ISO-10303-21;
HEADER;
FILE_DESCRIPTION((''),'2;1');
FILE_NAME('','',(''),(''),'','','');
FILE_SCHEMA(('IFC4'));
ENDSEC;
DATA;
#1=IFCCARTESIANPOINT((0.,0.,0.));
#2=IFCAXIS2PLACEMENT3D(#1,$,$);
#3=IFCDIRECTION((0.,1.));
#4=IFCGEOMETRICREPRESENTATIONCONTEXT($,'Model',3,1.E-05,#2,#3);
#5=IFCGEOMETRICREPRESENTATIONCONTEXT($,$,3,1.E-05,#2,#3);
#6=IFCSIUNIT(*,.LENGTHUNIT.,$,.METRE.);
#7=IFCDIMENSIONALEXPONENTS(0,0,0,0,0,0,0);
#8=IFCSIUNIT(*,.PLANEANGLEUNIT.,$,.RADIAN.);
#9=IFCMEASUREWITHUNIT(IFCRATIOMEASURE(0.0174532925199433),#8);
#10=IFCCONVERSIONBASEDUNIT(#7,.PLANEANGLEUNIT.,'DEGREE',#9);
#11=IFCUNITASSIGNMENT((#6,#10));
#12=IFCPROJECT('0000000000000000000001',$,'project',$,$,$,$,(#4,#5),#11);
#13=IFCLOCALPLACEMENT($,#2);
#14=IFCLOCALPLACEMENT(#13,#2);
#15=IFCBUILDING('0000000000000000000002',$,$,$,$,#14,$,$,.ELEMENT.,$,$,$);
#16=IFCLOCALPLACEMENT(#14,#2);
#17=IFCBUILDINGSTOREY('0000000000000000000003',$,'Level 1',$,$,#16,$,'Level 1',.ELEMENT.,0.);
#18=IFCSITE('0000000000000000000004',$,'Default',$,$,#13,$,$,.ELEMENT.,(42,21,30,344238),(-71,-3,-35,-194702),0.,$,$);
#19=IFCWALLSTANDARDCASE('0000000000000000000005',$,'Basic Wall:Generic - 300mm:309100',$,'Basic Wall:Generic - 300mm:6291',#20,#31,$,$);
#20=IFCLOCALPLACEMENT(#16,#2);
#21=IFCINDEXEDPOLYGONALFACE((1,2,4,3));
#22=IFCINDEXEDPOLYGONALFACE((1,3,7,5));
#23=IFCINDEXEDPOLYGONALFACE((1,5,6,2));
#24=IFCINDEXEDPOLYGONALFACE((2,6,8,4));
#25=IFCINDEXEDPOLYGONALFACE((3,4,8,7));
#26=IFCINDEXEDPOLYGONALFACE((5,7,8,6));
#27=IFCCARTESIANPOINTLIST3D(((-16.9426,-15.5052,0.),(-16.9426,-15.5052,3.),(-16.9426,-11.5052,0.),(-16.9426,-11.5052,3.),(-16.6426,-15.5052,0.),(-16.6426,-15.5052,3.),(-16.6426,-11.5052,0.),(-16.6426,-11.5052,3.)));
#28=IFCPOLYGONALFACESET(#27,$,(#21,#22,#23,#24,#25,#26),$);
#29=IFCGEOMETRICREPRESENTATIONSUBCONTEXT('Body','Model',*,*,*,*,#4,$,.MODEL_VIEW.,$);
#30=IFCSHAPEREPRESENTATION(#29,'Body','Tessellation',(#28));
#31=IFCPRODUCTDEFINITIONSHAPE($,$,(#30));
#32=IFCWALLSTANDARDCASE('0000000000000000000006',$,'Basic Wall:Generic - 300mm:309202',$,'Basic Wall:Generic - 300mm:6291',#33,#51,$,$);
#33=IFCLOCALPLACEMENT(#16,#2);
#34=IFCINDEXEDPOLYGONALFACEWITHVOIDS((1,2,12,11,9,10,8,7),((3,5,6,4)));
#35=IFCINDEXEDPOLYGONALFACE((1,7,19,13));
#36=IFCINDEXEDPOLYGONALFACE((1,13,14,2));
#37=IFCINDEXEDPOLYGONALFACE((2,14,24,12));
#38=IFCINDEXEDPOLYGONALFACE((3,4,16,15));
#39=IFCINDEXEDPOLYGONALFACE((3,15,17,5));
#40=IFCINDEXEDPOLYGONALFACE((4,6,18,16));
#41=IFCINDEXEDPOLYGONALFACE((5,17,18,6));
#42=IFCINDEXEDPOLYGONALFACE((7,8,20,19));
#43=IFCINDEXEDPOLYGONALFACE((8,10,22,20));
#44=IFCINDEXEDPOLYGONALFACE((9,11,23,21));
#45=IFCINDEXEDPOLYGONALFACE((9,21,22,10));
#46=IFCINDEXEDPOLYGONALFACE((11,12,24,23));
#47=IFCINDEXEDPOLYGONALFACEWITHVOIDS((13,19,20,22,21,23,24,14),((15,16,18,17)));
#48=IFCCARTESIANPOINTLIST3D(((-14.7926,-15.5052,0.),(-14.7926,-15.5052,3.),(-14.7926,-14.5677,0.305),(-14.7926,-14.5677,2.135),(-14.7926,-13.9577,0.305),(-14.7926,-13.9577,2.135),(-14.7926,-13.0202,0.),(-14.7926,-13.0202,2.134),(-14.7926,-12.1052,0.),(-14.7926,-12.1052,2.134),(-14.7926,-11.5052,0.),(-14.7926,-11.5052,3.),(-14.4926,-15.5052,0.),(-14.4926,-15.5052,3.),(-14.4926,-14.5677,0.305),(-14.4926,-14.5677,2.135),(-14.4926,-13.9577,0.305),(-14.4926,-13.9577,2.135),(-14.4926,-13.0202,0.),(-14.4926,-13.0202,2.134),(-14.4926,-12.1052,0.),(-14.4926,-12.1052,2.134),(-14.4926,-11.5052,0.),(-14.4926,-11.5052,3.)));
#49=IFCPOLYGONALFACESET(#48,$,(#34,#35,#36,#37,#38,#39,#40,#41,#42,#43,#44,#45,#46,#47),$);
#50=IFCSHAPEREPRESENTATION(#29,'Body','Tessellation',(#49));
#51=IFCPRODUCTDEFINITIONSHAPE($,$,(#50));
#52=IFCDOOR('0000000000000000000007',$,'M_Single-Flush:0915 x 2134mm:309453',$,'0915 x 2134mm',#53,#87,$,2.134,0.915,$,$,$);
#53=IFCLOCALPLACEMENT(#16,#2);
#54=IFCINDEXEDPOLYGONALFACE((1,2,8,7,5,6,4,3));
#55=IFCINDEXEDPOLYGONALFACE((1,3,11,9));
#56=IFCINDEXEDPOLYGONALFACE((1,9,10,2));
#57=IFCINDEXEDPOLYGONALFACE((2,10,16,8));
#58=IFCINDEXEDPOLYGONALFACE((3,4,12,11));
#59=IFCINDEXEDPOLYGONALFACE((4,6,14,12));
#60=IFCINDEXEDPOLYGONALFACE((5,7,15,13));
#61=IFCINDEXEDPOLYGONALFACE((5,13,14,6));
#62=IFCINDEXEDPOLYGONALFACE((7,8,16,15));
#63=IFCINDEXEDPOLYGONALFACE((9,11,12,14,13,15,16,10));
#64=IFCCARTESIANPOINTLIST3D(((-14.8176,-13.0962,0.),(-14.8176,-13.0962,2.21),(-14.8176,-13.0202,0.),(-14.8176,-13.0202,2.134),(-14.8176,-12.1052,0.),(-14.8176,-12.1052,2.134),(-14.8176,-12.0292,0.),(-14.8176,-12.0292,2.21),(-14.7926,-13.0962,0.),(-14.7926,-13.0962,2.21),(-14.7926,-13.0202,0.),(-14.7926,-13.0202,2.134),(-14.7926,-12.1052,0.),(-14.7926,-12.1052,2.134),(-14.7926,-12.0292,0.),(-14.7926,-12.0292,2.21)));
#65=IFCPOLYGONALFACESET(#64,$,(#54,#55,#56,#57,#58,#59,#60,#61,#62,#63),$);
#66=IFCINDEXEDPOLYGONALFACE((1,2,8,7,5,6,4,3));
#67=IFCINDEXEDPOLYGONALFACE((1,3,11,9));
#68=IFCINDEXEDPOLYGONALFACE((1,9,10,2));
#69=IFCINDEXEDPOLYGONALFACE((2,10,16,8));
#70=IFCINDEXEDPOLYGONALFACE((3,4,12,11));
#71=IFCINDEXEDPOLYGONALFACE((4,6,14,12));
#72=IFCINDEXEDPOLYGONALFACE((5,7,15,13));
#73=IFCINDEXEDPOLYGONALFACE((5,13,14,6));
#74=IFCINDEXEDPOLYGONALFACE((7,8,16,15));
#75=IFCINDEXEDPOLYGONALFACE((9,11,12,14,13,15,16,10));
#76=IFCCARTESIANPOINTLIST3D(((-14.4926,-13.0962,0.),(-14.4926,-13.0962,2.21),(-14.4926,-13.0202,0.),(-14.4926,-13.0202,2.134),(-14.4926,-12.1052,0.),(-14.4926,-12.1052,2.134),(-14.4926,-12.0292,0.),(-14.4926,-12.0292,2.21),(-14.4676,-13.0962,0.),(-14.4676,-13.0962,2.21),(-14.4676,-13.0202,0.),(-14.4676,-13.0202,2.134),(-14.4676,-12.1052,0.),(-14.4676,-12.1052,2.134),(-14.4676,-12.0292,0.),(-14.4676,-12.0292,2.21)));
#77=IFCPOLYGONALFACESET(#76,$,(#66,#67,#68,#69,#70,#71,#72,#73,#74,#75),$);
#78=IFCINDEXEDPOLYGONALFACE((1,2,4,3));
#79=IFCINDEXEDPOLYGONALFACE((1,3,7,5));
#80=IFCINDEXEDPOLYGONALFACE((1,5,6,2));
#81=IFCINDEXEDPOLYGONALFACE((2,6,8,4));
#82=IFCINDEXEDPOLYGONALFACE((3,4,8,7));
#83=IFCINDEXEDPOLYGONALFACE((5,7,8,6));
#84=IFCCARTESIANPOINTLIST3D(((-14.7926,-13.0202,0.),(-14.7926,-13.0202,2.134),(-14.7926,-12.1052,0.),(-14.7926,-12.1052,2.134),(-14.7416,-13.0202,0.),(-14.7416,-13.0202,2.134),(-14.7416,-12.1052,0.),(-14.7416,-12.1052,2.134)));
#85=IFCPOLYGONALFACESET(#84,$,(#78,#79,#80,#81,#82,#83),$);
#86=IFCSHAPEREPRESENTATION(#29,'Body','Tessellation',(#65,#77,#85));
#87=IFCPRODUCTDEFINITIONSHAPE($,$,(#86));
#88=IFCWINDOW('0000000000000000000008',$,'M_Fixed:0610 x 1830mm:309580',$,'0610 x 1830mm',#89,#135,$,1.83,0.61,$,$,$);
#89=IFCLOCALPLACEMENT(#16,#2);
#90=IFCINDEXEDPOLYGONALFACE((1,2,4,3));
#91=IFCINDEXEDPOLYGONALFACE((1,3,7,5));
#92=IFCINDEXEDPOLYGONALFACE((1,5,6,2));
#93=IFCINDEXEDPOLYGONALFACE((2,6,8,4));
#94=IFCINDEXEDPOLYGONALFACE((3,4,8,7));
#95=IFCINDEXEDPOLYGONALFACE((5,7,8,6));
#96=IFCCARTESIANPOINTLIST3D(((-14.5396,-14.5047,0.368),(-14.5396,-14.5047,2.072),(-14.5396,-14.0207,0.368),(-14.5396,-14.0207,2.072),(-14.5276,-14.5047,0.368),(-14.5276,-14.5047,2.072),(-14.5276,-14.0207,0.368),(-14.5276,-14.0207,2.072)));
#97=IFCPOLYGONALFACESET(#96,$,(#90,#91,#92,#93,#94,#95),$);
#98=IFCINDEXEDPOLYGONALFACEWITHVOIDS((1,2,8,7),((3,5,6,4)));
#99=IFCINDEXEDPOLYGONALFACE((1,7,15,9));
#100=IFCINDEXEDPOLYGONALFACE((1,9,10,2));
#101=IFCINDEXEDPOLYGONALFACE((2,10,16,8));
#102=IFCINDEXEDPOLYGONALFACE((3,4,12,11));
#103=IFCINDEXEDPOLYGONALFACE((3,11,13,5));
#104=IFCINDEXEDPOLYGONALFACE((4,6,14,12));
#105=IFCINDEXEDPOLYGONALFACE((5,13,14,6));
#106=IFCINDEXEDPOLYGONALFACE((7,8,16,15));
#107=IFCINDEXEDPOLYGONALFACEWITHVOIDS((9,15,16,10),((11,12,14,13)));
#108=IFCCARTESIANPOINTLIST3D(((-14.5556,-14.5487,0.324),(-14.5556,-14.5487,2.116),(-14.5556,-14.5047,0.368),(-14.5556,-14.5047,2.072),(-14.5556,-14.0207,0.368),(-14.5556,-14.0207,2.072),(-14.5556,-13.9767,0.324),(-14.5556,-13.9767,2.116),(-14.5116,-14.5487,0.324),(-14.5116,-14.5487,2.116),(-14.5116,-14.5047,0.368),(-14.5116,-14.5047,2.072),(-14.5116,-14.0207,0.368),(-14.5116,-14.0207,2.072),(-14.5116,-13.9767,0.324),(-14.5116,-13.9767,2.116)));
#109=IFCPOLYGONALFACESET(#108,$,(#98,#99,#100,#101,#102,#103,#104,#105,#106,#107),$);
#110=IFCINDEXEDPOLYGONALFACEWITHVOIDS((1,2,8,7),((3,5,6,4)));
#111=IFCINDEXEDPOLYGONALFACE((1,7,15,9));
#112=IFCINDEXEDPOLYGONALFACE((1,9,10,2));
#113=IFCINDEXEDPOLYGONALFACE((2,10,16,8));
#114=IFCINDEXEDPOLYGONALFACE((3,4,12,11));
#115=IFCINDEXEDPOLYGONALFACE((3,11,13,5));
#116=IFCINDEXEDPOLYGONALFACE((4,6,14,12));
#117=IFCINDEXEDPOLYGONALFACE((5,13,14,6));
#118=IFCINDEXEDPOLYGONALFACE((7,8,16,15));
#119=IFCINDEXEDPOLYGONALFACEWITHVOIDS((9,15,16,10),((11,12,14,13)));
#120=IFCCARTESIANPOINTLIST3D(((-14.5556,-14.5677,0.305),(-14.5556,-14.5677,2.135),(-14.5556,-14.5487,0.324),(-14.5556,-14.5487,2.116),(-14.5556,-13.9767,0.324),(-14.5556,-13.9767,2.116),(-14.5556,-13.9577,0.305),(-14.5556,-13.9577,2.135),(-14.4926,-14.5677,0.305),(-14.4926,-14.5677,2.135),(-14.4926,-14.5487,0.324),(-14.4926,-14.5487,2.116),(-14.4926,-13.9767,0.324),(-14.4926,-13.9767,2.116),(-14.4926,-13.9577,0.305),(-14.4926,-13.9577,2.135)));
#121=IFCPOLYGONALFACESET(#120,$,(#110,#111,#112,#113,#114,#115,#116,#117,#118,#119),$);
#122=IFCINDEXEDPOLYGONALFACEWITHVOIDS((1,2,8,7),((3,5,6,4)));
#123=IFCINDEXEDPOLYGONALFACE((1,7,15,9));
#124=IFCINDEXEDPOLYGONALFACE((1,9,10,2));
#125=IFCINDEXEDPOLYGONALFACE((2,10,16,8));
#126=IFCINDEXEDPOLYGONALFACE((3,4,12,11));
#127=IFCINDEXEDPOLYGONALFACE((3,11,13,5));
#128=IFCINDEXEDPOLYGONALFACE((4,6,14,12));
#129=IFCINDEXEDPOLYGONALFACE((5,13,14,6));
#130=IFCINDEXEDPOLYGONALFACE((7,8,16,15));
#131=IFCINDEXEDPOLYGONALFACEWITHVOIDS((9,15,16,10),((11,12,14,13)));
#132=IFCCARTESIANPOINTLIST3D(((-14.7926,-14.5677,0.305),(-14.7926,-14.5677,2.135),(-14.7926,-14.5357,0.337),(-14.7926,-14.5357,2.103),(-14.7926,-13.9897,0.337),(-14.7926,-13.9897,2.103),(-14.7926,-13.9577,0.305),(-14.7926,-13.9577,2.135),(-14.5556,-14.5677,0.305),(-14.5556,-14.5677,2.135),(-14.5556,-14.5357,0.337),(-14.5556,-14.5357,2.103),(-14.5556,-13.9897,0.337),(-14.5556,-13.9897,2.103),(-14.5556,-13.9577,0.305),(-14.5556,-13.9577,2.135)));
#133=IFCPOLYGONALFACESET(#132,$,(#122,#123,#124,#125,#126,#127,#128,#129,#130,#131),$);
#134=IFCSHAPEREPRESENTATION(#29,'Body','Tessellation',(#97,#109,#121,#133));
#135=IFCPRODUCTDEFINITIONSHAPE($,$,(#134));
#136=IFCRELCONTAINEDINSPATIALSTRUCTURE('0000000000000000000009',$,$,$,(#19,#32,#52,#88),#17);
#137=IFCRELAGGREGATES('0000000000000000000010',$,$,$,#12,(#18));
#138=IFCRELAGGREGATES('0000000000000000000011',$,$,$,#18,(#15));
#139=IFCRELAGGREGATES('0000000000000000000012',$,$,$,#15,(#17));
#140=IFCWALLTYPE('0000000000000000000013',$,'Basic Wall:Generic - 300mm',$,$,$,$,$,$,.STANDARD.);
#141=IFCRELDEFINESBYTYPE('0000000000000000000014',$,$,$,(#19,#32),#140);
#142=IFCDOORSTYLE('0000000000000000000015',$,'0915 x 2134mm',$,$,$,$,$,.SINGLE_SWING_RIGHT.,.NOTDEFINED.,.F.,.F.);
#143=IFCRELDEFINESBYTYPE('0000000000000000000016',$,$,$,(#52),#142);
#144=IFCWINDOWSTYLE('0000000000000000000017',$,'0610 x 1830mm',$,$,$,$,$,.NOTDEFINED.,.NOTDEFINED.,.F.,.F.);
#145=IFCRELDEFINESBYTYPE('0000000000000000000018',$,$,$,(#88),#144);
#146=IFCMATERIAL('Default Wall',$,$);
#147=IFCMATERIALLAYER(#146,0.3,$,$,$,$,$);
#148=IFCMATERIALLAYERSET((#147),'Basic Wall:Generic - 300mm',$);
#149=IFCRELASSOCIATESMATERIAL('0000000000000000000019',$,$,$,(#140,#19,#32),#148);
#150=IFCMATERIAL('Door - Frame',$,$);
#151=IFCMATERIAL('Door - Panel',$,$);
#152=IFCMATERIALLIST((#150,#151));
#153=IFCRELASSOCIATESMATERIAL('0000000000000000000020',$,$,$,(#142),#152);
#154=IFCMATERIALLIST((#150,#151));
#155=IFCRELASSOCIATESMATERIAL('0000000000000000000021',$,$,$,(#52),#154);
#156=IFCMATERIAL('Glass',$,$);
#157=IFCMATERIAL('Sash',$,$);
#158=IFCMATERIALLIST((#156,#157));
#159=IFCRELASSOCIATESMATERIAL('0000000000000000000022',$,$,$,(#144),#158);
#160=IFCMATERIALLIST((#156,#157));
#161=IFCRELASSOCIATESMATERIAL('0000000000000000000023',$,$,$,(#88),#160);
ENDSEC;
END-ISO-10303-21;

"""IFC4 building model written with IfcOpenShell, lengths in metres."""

from ifc_helpers import new_model, entity, si_unit, converted_unit, direction, frame, frame_2d, origin, place, context, subcontext, project, spatial, polyline, rectangle, outline, extrude, source, transform, mapped, material, material_list, layer, layer_set, layer_usage, type_object, type_shapes, element, fill, save


model = new_model("IFC4")

# Units and contexts
model_context = context("Model", 3, precision=1e-05, world=origin(), true_north=direction((0.0, 1.0)))
context_of_model = context(None, 3, precision=1e-05, world=origin(), true_north=direction((0.0, 1.0)))
body_context = subcontext(model_context, "Body", "Model", "MODEL_VIEW")
ifc_project = project(units=[si_unit("LENGTHUNIT", "METRE"), converted_unit("PLANEANGLEUNIT", "DEGREE", entity("IfcRatioMeasure", 0.0174532925199433), si_unit("PLANEANGLEUNIT", "RADIAN"), dimensions=[0, 0, 0, 0, 0, 0, 0])], contexts=[model_context, context_of_model])

# Site, building, storey
site_placement = place(None, origin())
site = spatial("IfcSite", under=ifc_project, at=site_placement, Name="Default", CompositionType="ELEMENT", RefLatitude=(42, 21, 30, 344238), RefLongitude=(-71, -3, -35, -194702), RefElevation=0.0)
building_placement = place(site_placement, origin())
building = spatial("IfcBuilding", under=site, at=building_placement, CompositionType="ELEMENT")
storey_placement = place(building_placement, origin())
storey = spatial("IfcBuildingStorey", under=building, at=storey_placement, Name="Level 1", LongName="Level 1", CompositionType="ELEMENT", Elevation=0.0)

# Wall
ifc_material_1 = material(Name="Default Wall")
ifc_layer = layer(ifc_material_1, 0.3)
ifc_layer_set = layer_set([ifc_layer], Name="Basic Wall:Generic - 300mm")
ifc_layer_usage_1 = layer_usage(ifc_layer_set, "AXIS2", "NEGATIVE", 0.15)
wall_type = type_object("IfcWallType", Name="Basic Wall:Generic - 300mm", PredefinedType="STANDARD", material=ifc_layer_set)
wall_1_placement = place(storey_placement, frame((-16.7926, -15.5052, 0.0), z_axis=(0.0, 0.0, 1.0), x_axis=(0.0, 1.0, 0.0)))
element("IfcWallStandardCase", 1, at=wall_1_placement, inside=storey, type_object=wall_type, material=ifc_layer_usage_1, Name="Basic Wall:Generic - 300mm:309100", ObjectType="Basic Wall:Generic - 300mm:6291", context=body_context, shape_type="SweptSolid", body=[
    extrude(rectangle(XDim=4.0, YDim=0.3, at=frame_2d((2.0, 0.0), x_axis=(-1.0, 0.0))), origin(), (0.0, 0.0, 1.0), 3.0),
])

# Wall, openings, door, window
ifc_layer_usage_2 = layer_usage(ifc_layer_set, "AXIS2", "NEGATIVE", 0.15)
wall_2_placement = place(storey_placement, frame((-14.6426, -15.5052, 0.0), z_axis=(0.0, 0.0, 1.0), x_axis=(0.0, 1.0, 0.0)))
wall_2 = element("IfcWallStandardCase", 2, at=wall_2_placement, inside=storey, type_object=wall_type, material=ifc_layer_usage_2, Name="Basic Wall:Generic - 300mm:309202", ObjectType="Basic Wall:Generic - 300mm:6291", context=body_context, shape_type="SweptSolid", body=[
    extrude(rectangle(XDim=4.0, YDim=0.3, at=frame_2d((2.0, 0.0), x_axis=(-1.0, 0.0))), origin(), (0.0, 0.0, 1.0), 3.0),
])
opening_1_placement = place(wall_2_placement, frame((2.485, -0.15, 0.0)))
opening_1 = element("IfcOpeningElement", 3, at=opening_1_placement, cuts=wall_2, ObjectType="Opening", context=body_context, shape_type="SweptSolid", body=[
    extrude(rectangle(XDim=0.915, YDim=2.134, at=frame_2d((1.067, 0.4575), x_axis=(0.0, 1.0))), frame((0.0, 0.0, 0.0), z_axis=(0.0, 1.0, 0.0), x_axis=(0.0, 0.0, 1.0)), (0.0, 0.0, 1.0), 0.3),
])
opening_2_placement = place(wall_2_placement, frame((1.5475, 0.15, 0.305)))
opening_2 = element("IfcOpeningElement", 4, at=opening_2_placement, cuts=wall_2, ObjectType="Opening", context=body_context, shape_type="SweptSolid", body=[
    extrude(rectangle(XDim=1.83, YDim=0.61, at=frame_2d((0.915, 0.305), x_axis=(1.0, 0.0))), frame((0.0, 0.0, 0.0), z_axis=(0.0, -1.0, 0.0), x_axis=(0.0, 0.0, 1.0)), (0.0, 0.0, 1.0), 0.3),
])
ifc_material_2 = material(Name="Door - Frame")
ifc_material_3 = material(Name="Door - Panel")
ifc_material_list_1 = material_list([ifc_material_2, ifc_material_3])
ifc_material_list_2 = material_list([ifc_material_2, ifc_material_3])
door_style = type_object("IfcDoorStyle", Name="0915 x 2134mm", ConstructionType="NOTDEFINED", OperationType="SINGLE_SWING_RIGHT", ParameterTakesPrecedence=False, Sizeable=False, material=ifc_material_list_2)
shared_shape_1 = source(origin(), body_context, "Body", "SweptSolid", [
    extrude(outline(polyline([(-0.5335, -1.124), (0.5335, -1.124), (0.5335, 1.086), (0.4575, 1.086), (0.4575, -1.048), (-0.4575, -1.048), (-0.4575, 1.086), (-0.5335, 1.086), (-0.5335, -1.124)])), frame((0.4575, 0.3, 1.086), z_axis=(0.0, 1.0, 0.0), x_axis=(1.0, 0.0, 0.0)), (0.0, 0.0, 1.0), 0.025),
    extrude(outline(polyline([(-1.124, -0.5335), (1.086, -0.5335), (1.086, -0.4575), (-1.048, -0.4575), (-1.048, 0.4575), (1.086, 0.4575), (1.086, 0.5335), (-1.124, 0.5335), (-1.124, -0.5335)])), frame((0.4575, -0.025, 1.086), z_axis=(0.0, 1.0, 0.0), x_axis=(0.0, 0.0, -1.0)), (0.0, 0.0, 1.0), 0.025),
    extrude(rectangle(XDim=0.051, YDim=0.915, at=frame_2d((0.0, 0.0), x_axis=(1.0, 0.0))), frame((0.4575, 0.2745, 0.0), z_axis=(0.0, 0.0, 1.0), x_axis=(0.0, 1.0, 0.0)), (0.0, 0.0, 1.0), 2.134),
])
type_shapes(door_style, [shared_shape_1])
door_placement = place(opening_1_placement, origin())
door = element("IfcDoor", 5, at=door_placement, inside=storey, type_object=door_style, material=ifc_material_list_1, Name="M_Single-Flush:0915 x 2134mm:309453", ObjectType="0915 x 2134mm", OverallHeight=2.134, OverallWidth=0.915, context=body_context, shape_type="MappedRepresentation", body=[
    mapped(shared_shape_1, transform((0.0, 0.0, 0.0), scale=1.0)),
])
fill(opening_1, door)
ifc_material_4 = material(Name="Glass")
ifc_material_5 = material(Name="Sash")
ifc_material_list_3 = material_list([ifc_material_4, ifc_material_5])
ifc_material_list_4 = material_list([ifc_material_4, ifc_material_5])
window_style_1 = type_object("IfcWindowStyle", Name="0610 x 1830mm", ConstructionType="NOTDEFINED", OperationType="NOTDEFINED", ParameterTakesPrecedence=False, Sizeable=False, material=ifc_material_list_4)
shared_shape_2 = source(origin(), body_context, "Body", "SweptSolid", [
    extrude(rectangle(XDim=0.012, YDim=0.484, at=frame_2d((0.0, 0.0), x_axis=(1.0, 0.0))), frame((0.305, 0.259, 0.063), z_axis=(0.0, 0.0, 1.0), x_axis=(0.0, -1.0, 0.0)), (0.0, 0.0, 1.0), 1.704),
    extrude(outline(polyline([(-0.286, -0.896), (0.286, -0.896), (0.286, 0.896), (-0.286, 0.896), (-0.286, -0.896)]), holes=[polyline([(-0.242, -0.852), (-0.242, 0.852), (0.242, 0.852), (0.242, -0.852), (-0.242, -0.852)])]), frame((0.305, 0.237, 0.915), z_axis=(0.0, 1.0, 0.0), x_axis=(1.0, 0.0, 0.0)), (0.0, 0.0, 1.0), 0.044),
    extrude(outline(polyline([(-0.305, -0.915), (0.305, -0.915), (0.305, 0.915), (-0.305, 0.915), (-0.305, -0.915)]), holes=[polyline([(-0.286, -0.896), (-0.286, 0.896), (0.286, 0.896), (0.286, -0.896), (-0.286, -0.896)])]), frame((0.305, 0.237, 0.915), z_axis=(0.0, 1.0, 0.0), x_axis=(1.0, 0.0, 0.0)), (0.0, 0.0, 1.0), 0.063),
    extrude(outline(polyline([(-0.305, -0.915), (0.305, -0.915), (0.305, 0.915), (-0.305, 0.915), (-0.305, -0.915)]), holes=[polyline([(-0.273, -0.883), (-0.273, 0.883), (0.273, 0.883), (0.273, -0.883), (-0.273, -0.883)])]), frame((0.305, 0.0, 0.915), z_axis=(0.0, 1.0, 0.0), x_axis=(1.0, 0.0, 0.0)), (0.0, 0.0, 1.0), 0.237),
])
type_shapes(window_style_1, [shared_shape_2])
window_1_placement = place(opening_2_placement, frame((0.0, 0.0, 0.0), z_axis=(0.0, 0.0, 1.0), x_axis=(-1.0, 0.0, 0.0)))
window_1 = element("IfcWindow", 6, at=window_1_placement, inside=storey, type_object=window_style_1, material=ifc_material_list_3, Name="M_Fixed:0610 x 1830mm:309580", ObjectType="0610 x 1830mm", OverallHeight=1.83, OverallWidth=0.61, context=body_context, shape_type="MappedRepresentation", body=[
    mapped(shared_shape_2, transform((0.0, 0.0, 0.0), scale=1.0)),
])
fill(opening_2, window_1)

save(model, "model.ifc")
